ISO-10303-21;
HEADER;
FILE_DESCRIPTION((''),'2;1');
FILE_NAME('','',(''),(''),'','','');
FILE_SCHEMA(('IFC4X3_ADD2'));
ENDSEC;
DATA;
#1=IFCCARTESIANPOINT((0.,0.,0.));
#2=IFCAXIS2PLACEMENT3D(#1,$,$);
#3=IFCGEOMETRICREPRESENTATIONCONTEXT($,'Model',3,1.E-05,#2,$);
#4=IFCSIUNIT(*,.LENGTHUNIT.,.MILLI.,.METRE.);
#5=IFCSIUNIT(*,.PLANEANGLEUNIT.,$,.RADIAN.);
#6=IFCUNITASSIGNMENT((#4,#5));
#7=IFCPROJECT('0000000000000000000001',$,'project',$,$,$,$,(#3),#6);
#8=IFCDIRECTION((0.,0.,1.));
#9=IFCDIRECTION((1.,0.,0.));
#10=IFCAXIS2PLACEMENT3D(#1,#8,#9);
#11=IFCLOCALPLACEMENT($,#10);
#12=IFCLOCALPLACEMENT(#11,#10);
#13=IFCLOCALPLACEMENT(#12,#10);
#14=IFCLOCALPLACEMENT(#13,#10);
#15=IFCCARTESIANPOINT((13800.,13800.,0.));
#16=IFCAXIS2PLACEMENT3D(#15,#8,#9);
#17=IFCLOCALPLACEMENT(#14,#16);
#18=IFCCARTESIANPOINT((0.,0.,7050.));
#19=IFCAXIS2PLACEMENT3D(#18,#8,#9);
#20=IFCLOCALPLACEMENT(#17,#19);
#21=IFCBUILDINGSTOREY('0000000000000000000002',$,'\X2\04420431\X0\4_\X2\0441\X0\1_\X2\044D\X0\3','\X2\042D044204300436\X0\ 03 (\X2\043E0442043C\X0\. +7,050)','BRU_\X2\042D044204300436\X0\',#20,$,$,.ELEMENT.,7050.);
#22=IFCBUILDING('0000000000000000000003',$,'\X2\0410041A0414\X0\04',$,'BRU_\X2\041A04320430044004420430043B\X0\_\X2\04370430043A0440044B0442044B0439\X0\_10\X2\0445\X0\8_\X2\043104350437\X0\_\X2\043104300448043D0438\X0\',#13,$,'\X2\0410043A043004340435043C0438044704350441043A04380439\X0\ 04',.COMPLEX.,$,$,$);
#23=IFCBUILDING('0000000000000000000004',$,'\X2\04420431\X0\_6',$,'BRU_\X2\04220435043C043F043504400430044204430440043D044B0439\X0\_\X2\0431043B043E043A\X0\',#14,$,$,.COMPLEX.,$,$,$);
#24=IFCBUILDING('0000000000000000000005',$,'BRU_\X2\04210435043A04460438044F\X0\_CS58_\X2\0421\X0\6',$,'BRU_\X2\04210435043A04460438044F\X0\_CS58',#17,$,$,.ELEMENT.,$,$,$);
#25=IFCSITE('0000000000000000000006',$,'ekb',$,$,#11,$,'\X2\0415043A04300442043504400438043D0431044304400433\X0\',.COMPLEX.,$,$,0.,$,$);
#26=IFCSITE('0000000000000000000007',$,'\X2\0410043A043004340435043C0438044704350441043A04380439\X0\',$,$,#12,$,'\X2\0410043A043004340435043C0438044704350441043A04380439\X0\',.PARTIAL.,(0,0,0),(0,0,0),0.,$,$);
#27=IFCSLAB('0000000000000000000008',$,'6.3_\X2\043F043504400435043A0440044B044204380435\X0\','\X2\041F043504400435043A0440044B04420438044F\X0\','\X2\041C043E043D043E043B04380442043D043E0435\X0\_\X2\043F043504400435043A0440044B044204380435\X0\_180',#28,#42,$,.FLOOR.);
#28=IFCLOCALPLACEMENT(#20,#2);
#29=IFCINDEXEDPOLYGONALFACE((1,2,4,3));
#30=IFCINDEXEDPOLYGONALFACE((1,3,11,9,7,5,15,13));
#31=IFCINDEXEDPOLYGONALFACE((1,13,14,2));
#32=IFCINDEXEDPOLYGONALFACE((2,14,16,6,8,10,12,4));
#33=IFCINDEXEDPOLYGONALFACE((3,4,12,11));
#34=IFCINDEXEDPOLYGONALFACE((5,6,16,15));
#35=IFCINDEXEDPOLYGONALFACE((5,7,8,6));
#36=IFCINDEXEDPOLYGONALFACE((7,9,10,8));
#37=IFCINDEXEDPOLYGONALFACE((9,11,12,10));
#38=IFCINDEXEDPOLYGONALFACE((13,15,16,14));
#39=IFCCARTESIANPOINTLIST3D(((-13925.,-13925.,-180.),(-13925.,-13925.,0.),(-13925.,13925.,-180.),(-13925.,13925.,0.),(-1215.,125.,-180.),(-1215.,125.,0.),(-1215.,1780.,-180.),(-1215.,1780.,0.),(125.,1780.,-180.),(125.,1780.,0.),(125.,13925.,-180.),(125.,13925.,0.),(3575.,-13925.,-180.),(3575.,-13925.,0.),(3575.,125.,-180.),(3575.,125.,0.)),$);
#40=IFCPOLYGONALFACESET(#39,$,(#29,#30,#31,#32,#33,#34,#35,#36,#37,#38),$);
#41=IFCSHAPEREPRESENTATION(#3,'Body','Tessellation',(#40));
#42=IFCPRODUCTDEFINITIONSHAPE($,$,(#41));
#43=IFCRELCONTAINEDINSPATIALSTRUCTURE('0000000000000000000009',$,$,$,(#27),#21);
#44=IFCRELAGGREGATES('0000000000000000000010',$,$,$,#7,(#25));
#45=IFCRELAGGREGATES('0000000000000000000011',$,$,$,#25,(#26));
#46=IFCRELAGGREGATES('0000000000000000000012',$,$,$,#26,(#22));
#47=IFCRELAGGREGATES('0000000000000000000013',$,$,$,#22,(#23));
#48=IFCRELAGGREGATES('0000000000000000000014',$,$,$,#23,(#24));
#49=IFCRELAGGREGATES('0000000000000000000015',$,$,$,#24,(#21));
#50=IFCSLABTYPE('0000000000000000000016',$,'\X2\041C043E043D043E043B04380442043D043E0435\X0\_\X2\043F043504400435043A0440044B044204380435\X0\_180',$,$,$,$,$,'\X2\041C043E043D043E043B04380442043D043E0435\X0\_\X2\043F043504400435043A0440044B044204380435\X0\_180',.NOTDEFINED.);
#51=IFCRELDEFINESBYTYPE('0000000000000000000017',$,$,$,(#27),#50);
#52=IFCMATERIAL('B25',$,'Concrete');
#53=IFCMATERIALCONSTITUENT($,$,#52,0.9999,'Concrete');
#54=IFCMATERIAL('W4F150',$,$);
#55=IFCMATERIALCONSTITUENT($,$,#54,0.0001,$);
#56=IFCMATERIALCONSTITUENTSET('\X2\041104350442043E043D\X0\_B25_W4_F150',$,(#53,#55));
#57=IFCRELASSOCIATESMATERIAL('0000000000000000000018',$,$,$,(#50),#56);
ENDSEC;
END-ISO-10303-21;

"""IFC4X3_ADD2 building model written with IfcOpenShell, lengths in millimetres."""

from ifc_helpers import new_model, si_unit, frame, origin, origin_with_axes, place, context, project, spatial, polyline, outline, extrude, material, constituent, constituent_set, type_object, element, save


model = new_model("IFC4X3_ADD2")

# Units and contexts
model_context = context("Model", 3, precision=1e-05, world=origin())
ifc_project = project(units=[si_unit("LENGTHUNIT", "METRE", prefix="MILLI"), si_unit("PLANEANGLEUNIT", "RADIAN")], contexts=[model_context])

# Sites, buildings, storey
site_1_placement = place(None, origin_with_axes())
site_1 = spatial("IfcSite", under=ifc_project, at=site_1_placement, Name="ekb", LongName="Екатеринбург", CompositionType="COMPLEX", RefElevation=0.0)
site_2_placement = place(site_1_placement, origin_with_axes())
site_2 = spatial("IfcSite", under=site_1, at=site_2_placement, Name="Академический", LongName="Академический", CompositionType="PARTIAL", RefLatitude=(0, 0, 0), RefLongitude=(0, 0, 0), RefElevation=0.0)
building_1_placement = place(site_2_placement, origin_with_axes())
building_1 = spatial("IfcBuilding", under=site_2, at=building_1_placement, Name="АКД04", ObjectType="BRU_Квартал_закрытый_10х8_без_башни", LongName="Академический 04", CompositionType="COMPLEX")
building_2_placement = place(building_1_placement, origin_with_axes())
building_2 = spatial("IfcBuilding", under=building_1, at=building_2_placement, Name="тб_6", ObjectType="BRU_Температурный_блок", CompositionType="COMPLEX")
building_3_placement = place(building_2_placement, frame((13800.0, 13800.0, 0.0), z_axis=(0.0, 0.0, 1.0), x_axis=(1.0, 0.0, 0.0)))
building_3 = spatial("IfcBuilding", under=building_2, at=building_3_placement, Name="BRU_Секция_CS58_С6", ObjectType="BRU_Секция_CS58", CompositionType="ELEMENT")
storey_placement = place(building_3_placement, frame((0.0, 0.0, 7050.0), z_axis=(0.0, 0.0, 1.0), x_axis=(1.0, 0.0, 0.0)))
storey = spatial("IfcBuildingStorey", under=building_3, at=storey_placement, Name="тб4_с1_э3", Description="Этаж 03 (отм. +7,050)", ObjectType="BRU_Этаж", CompositionType="ELEMENT", Elevation=7050.0)

# Shared definitions
ifc_material_1 = material(Name="B25", Category="Concrete")
ifc_material_2 = material(Name="W4F150")

# Slab
ifc_constituent_1 = constituent(ifc_material_1, Category="Concrete", fraction=0.9999)
ifc_constituent_2 = constituent(ifc_material_2, fraction=0.0001)
ifc_constituent_set_1 = constituent_set(constituents=[ifc_constituent_1, ifc_constituent_2], Name="Бетон_B25_W4_F150")
slab_type = type_object("IfcSlabType", Name="Монолитное_перекрытие_180", ElementType="Монолитное_перекрытие_180", PredefinedType="NOTDEFINED", material=ifc_constituent_set_1)
slab_placement = place(storey_placement, frame((0.0, 0.0, -180.0), z_axis=(0.0, 0.0, 1.0), x_axis=(1.0, 0.0, 0.0)))
element("IfcSlab", 1, at=slab_placement, inside=storey, type_object=slab_type, Name="6.3_перекрытие", Description="Перекрытия", ObjectType="Монолитное_перекрытие_180", PredefinedType="FLOOR", context=model_context, shape_type="SweptSolid", body=[
    extrude(outline(polyline([(-13925.0, -13925.0), (3575.0, -13925.0), (3575.0, 125.0), (-1215.0, 125.0), (-1215.0, 1780.0), (125.0, 1780.0), (125.0, 13925.0), (-13925.0, 13925.0), (-13925.0, -13925.0)])), origin_with_axes(), (0.0, 0.0, 1.0), 180.0),
])

save(model, "model.ifc")
